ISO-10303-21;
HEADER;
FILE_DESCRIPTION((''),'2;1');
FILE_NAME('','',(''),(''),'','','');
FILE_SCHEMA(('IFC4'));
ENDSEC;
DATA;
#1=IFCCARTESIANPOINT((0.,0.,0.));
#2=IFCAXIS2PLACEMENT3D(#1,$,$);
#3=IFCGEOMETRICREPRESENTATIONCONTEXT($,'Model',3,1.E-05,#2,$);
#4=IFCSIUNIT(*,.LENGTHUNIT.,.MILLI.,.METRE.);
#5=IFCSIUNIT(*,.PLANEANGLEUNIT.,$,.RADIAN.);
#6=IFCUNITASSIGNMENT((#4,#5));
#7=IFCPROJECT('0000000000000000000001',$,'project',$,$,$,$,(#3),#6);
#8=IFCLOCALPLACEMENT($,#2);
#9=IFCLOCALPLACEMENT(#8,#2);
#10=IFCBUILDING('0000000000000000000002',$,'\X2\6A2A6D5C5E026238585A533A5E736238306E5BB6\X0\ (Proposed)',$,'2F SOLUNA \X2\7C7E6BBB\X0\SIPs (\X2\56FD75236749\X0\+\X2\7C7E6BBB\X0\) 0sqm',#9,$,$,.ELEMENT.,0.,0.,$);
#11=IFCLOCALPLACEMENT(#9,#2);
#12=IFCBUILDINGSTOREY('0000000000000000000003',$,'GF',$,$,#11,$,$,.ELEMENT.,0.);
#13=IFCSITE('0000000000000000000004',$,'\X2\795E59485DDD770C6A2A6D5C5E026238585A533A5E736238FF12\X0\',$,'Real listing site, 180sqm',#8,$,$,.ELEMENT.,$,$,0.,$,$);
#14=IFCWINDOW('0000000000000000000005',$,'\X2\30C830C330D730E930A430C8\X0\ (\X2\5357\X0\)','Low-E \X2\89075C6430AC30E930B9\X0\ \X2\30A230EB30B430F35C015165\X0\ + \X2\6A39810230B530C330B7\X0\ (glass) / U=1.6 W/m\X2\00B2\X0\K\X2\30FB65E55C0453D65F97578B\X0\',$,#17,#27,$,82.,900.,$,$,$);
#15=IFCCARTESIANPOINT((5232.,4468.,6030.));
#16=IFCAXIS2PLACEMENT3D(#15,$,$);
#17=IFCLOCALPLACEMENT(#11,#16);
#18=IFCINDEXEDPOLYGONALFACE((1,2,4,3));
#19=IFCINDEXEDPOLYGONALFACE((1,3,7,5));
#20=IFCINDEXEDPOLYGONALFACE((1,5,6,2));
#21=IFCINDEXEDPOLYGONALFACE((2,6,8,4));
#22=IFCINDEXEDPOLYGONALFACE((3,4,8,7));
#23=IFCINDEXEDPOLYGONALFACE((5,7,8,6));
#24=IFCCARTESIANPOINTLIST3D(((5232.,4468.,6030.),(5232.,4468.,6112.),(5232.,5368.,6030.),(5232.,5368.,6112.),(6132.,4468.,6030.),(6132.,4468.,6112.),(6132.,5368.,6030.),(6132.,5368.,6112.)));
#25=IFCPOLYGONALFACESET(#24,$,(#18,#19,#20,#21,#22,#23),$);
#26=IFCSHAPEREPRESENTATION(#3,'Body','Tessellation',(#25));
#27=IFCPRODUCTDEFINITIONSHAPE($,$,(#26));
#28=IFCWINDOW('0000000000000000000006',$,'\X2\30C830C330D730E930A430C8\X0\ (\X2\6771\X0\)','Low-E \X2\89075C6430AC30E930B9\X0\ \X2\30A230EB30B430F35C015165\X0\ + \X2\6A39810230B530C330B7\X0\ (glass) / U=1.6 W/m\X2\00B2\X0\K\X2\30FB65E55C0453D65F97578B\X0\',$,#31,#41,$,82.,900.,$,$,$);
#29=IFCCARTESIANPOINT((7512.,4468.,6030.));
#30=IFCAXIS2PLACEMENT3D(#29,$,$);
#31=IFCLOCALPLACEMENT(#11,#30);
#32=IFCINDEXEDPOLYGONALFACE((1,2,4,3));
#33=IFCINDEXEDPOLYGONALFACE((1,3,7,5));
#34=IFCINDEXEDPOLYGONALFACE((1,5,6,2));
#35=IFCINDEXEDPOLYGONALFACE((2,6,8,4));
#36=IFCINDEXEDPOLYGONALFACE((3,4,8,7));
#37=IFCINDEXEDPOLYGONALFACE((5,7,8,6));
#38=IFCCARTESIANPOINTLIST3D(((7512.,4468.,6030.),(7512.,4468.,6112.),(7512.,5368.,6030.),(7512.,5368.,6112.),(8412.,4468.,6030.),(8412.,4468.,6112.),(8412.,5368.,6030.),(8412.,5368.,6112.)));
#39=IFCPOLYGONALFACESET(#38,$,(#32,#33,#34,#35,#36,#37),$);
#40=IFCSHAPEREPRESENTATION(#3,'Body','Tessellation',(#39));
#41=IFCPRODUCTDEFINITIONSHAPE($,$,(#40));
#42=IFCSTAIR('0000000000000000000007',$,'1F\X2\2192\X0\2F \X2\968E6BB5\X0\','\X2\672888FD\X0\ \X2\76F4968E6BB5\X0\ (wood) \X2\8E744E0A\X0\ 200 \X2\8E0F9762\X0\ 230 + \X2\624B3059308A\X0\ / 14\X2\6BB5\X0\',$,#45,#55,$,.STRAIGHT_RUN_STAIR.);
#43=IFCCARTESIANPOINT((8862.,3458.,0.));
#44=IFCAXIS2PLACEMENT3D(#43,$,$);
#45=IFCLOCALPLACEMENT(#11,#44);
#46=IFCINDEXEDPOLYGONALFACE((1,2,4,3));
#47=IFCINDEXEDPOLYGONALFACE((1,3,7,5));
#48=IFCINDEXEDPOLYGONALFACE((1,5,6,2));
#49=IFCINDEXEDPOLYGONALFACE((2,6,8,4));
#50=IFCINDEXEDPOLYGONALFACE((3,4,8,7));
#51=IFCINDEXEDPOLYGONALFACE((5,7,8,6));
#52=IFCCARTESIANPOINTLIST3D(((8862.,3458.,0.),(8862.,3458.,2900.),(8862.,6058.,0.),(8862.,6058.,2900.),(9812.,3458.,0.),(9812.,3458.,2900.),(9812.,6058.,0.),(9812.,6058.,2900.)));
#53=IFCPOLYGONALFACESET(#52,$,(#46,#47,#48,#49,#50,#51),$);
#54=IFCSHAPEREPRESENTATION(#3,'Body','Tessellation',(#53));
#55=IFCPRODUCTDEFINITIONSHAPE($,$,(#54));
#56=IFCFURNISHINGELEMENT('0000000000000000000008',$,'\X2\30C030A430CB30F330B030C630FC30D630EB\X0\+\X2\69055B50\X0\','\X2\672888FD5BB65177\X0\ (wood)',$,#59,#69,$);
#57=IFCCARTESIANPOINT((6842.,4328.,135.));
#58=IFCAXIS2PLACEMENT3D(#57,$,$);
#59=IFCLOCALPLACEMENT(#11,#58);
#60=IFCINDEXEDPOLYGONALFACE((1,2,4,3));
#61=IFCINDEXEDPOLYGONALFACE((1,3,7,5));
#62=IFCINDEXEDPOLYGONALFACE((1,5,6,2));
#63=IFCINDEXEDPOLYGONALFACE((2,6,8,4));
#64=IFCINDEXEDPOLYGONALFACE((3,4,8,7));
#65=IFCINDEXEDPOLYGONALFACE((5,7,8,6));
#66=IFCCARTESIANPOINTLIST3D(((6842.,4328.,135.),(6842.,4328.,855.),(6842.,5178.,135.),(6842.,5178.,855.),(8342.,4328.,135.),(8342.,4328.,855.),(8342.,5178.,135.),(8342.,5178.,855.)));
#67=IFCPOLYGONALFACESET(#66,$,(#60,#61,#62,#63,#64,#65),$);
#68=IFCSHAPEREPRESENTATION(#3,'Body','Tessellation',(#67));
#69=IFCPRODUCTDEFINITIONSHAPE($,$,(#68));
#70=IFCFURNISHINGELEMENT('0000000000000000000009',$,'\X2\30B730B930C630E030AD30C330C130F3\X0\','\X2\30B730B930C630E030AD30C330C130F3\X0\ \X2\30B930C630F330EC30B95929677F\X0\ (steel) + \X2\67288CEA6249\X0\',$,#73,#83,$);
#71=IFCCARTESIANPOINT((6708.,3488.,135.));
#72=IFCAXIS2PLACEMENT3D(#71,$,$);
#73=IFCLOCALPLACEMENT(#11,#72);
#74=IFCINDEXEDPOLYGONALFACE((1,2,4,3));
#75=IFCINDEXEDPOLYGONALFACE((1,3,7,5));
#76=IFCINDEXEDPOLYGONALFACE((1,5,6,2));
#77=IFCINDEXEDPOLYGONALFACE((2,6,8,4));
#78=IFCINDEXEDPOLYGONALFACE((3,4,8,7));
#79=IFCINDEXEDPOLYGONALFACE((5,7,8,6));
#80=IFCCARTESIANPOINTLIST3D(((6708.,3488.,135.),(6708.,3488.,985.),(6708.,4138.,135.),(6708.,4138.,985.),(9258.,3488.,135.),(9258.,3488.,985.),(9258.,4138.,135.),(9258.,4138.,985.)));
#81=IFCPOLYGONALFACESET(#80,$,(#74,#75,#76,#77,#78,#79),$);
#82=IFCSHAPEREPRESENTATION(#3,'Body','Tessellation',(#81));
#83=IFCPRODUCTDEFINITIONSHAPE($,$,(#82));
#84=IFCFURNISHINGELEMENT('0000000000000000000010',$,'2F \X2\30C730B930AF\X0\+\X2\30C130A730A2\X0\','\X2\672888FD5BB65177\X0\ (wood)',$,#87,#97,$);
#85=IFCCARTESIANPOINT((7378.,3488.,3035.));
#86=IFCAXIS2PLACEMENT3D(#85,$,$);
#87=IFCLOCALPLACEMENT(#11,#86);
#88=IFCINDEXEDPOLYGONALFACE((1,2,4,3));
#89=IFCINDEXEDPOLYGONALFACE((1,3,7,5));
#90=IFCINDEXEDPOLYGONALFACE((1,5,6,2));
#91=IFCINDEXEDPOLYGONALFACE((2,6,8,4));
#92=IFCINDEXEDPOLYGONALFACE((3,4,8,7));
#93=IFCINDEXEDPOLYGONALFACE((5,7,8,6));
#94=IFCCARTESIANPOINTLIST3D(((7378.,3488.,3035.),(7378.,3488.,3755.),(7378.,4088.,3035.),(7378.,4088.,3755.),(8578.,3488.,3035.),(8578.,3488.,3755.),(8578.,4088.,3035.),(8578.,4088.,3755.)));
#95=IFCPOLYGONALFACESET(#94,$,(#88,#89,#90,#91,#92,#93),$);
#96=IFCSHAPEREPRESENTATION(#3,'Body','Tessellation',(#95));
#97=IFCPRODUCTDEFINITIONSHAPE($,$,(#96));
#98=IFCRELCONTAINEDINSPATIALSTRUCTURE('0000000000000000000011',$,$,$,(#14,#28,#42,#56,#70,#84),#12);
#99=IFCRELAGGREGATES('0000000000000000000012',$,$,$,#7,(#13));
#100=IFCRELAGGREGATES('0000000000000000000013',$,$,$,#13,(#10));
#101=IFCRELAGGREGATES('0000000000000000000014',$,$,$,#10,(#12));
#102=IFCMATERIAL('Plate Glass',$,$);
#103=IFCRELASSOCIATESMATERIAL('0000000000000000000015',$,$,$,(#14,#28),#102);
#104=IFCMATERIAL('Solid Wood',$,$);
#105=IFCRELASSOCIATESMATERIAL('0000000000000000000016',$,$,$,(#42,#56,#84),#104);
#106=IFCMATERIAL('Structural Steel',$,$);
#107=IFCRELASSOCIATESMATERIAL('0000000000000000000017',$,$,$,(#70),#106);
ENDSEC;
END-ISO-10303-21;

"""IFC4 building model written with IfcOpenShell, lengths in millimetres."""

from ifc_helpers import new_model, si_unit, frame, frame_2d, origin, place, context, project, spatial, rectangle, extrude, material, element, save


model = new_model("IFC4")

# Units and contexts
model_context = context("Model", 3, precision=1e-05, world=origin())
ifc_project = project(units=[si_unit("LENGTHUNIT", "METRE", prefix="MILLI"), si_unit("PLANEANGLEUNIT", "RADIAN")], contexts=[model_context])

# Site, building, storey
site_placement = place(None, origin())
site = spatial("IfcSite", under=ifc_project, at=site_placement, Name="神奈川県横浜市戸塚区平戸２", ObjectType="Real listing site, 180sqm", CompositionType="ELEMENT", RefElevation=0.0)
building_placement = place(site_placement, origin())
building = spatial("IfcBuilding", under=site, at=building_placement, Name="横浜市戸塚区平戸の家 (Proposed)", ObjectType="2F SOLUNA 籾殻SIPs (国産杉+籾殻) 0sqm", CompositionType="ELEMENT", ElevationOfRefHeight=0.0, ElevationOfTerrain=0.0)
storey_placement = place(building_placement, origin())
storey = spatial("IfcBuildingStorey", under=building, at=storey_placement, Name="GF", CompositionType="ELEMENT", Elevation=0.0)

# Shared definitions
ifc_material_1 = material(Name="Solid Wood")

# Shared definitions
ifc_material_2 = material(Name="Plate Glass")

# Windows
window_1_placement = place(storey_placement, frame((5232.0, 4468.0, 6030.0)))
element("IfcWindow", 1, at=window_1_placement, inside=storey, material=ifc_material_2, Name="トップライト (南)", Description="Low-E 複層ガラス アルゴン封入 + 樹脂サッシ (glass) / U=1.6 W/m²K・日射取得型", OverallHeight=82.0, OverallWidth=900.0, context=model_context, shape_type="SweptSolid", body=[
    extrude(rectangle(XDim=900.0, YDim=900.0, at=frame_2d((450.0, 450.0))), frame((5232.0, 4468.0, 6030.0)), (0.0, 0.0, 1.0), 82.0),
])
window_2_placement = place(storey_placement, frame((7512.0, 4468.0, 6030.0)))
element("IfcWindow", 2, at=window_2_placement, inside=storey, material=ifc_material_2, Name="トップライト (東)", Description="Low-E 複層ガラス アルゴン封入 + 樹脂サッシ (glass) / U=1.6 W/m²K・日射取得型", OverallHeight=82.0, OverallWidth=900.0, context=model_context, shape_type="SweptSolid", body=[
    extrude(rectangle(XDim=900.0, YDim=900.0, at=frame_2d((450.0, 450.0))), frame((7512.0, 4468.0, 6030.0)), (0.0, 0.0, 1.0), 82.0),
])

# Stair
stair_placement = place(storey_placement, frame((8862.0, 3458.0, 0.0)))
element("IfcStair", 3, at=stair_placement, inside=storey, material=ifc_material_1, Name="1F→2F 階段", Description="木製 直階段 (wood) 蹴上 200 踏面 230 + 手すり / 14段", PredefinedType="STRAIGHT_RUN_STAIR", context=model_context, shape_type="SweptSolid", body=[
    extrude(rectangle(XDim=950.0, YDim=2600.0, at=frame_2d((475.0, 1300.0))), frame((8862.0, 3458.0, 0.0)), (0.0, 0.0, 1.0), 2900.0),
])

# Furnishing elements
furnishing_1_placement = place(storey_placement, frame((6842.0, 4328.0, 135.0)))
element("IfcFurnishingElement", 4, at=furnishing_1_placement, inside=storey, material=ifc_material_1, Name="ダイニングテーブル+椅子", Description="木製家具 (wood)", context=model_context, shape_type="SweptSolid", body=[
    extrude(rectangle(XDim=1500.0, YDim=850.0, at=frame_2d((750.0, 425.0))), frame((6842.0, 4328.0, 135.0)), (0.0, 0.0, 1.0), 720.0),
])
ifc_material_3 = material(Name="Structural Steel")
furnishing_2_placement = place(storey_placement, frame((6708.0, 3488.0, 135.0)))
element("IfcFurnishingElement", 5, at=furnishing_2_placement, inside=storey, material=ifc_material_3, Name="システムキッチン", Description="システムキッチン ステンレス天板 (steel) + 木質扉", context=model_context, shape_type="SweptSolid", body=[
    extrude(rectangle(XDim=2550.0, YDim=650.0, at=frame_2d((1275.0, 325.0))), frame((6708.0, 3488.0, 135.0)), (0.0, 0.0, 1.0), 850.0),
])
furnishing_3_placement = place(storey_placement, frame((7378.0, 3488.0, 3035.0)))
element("IfcFurnishingElement", 6, at=furnishing_3_placement, inside=storey, material=ifc_material_1, Name="2F デスク+チェア", Description="木製家具 (wood)", context=model_context, shape_type="SweptSolid", body=[
    extrude(rectangle(XDim=1200.0, YDim=600.0, at=frame_2d((600.0, 300.0))), frame((7378.0, 3488.0, 3035.0)), (0.0, 0.0, 1.0), 720.0),
])

save(model, "model.ifc")
